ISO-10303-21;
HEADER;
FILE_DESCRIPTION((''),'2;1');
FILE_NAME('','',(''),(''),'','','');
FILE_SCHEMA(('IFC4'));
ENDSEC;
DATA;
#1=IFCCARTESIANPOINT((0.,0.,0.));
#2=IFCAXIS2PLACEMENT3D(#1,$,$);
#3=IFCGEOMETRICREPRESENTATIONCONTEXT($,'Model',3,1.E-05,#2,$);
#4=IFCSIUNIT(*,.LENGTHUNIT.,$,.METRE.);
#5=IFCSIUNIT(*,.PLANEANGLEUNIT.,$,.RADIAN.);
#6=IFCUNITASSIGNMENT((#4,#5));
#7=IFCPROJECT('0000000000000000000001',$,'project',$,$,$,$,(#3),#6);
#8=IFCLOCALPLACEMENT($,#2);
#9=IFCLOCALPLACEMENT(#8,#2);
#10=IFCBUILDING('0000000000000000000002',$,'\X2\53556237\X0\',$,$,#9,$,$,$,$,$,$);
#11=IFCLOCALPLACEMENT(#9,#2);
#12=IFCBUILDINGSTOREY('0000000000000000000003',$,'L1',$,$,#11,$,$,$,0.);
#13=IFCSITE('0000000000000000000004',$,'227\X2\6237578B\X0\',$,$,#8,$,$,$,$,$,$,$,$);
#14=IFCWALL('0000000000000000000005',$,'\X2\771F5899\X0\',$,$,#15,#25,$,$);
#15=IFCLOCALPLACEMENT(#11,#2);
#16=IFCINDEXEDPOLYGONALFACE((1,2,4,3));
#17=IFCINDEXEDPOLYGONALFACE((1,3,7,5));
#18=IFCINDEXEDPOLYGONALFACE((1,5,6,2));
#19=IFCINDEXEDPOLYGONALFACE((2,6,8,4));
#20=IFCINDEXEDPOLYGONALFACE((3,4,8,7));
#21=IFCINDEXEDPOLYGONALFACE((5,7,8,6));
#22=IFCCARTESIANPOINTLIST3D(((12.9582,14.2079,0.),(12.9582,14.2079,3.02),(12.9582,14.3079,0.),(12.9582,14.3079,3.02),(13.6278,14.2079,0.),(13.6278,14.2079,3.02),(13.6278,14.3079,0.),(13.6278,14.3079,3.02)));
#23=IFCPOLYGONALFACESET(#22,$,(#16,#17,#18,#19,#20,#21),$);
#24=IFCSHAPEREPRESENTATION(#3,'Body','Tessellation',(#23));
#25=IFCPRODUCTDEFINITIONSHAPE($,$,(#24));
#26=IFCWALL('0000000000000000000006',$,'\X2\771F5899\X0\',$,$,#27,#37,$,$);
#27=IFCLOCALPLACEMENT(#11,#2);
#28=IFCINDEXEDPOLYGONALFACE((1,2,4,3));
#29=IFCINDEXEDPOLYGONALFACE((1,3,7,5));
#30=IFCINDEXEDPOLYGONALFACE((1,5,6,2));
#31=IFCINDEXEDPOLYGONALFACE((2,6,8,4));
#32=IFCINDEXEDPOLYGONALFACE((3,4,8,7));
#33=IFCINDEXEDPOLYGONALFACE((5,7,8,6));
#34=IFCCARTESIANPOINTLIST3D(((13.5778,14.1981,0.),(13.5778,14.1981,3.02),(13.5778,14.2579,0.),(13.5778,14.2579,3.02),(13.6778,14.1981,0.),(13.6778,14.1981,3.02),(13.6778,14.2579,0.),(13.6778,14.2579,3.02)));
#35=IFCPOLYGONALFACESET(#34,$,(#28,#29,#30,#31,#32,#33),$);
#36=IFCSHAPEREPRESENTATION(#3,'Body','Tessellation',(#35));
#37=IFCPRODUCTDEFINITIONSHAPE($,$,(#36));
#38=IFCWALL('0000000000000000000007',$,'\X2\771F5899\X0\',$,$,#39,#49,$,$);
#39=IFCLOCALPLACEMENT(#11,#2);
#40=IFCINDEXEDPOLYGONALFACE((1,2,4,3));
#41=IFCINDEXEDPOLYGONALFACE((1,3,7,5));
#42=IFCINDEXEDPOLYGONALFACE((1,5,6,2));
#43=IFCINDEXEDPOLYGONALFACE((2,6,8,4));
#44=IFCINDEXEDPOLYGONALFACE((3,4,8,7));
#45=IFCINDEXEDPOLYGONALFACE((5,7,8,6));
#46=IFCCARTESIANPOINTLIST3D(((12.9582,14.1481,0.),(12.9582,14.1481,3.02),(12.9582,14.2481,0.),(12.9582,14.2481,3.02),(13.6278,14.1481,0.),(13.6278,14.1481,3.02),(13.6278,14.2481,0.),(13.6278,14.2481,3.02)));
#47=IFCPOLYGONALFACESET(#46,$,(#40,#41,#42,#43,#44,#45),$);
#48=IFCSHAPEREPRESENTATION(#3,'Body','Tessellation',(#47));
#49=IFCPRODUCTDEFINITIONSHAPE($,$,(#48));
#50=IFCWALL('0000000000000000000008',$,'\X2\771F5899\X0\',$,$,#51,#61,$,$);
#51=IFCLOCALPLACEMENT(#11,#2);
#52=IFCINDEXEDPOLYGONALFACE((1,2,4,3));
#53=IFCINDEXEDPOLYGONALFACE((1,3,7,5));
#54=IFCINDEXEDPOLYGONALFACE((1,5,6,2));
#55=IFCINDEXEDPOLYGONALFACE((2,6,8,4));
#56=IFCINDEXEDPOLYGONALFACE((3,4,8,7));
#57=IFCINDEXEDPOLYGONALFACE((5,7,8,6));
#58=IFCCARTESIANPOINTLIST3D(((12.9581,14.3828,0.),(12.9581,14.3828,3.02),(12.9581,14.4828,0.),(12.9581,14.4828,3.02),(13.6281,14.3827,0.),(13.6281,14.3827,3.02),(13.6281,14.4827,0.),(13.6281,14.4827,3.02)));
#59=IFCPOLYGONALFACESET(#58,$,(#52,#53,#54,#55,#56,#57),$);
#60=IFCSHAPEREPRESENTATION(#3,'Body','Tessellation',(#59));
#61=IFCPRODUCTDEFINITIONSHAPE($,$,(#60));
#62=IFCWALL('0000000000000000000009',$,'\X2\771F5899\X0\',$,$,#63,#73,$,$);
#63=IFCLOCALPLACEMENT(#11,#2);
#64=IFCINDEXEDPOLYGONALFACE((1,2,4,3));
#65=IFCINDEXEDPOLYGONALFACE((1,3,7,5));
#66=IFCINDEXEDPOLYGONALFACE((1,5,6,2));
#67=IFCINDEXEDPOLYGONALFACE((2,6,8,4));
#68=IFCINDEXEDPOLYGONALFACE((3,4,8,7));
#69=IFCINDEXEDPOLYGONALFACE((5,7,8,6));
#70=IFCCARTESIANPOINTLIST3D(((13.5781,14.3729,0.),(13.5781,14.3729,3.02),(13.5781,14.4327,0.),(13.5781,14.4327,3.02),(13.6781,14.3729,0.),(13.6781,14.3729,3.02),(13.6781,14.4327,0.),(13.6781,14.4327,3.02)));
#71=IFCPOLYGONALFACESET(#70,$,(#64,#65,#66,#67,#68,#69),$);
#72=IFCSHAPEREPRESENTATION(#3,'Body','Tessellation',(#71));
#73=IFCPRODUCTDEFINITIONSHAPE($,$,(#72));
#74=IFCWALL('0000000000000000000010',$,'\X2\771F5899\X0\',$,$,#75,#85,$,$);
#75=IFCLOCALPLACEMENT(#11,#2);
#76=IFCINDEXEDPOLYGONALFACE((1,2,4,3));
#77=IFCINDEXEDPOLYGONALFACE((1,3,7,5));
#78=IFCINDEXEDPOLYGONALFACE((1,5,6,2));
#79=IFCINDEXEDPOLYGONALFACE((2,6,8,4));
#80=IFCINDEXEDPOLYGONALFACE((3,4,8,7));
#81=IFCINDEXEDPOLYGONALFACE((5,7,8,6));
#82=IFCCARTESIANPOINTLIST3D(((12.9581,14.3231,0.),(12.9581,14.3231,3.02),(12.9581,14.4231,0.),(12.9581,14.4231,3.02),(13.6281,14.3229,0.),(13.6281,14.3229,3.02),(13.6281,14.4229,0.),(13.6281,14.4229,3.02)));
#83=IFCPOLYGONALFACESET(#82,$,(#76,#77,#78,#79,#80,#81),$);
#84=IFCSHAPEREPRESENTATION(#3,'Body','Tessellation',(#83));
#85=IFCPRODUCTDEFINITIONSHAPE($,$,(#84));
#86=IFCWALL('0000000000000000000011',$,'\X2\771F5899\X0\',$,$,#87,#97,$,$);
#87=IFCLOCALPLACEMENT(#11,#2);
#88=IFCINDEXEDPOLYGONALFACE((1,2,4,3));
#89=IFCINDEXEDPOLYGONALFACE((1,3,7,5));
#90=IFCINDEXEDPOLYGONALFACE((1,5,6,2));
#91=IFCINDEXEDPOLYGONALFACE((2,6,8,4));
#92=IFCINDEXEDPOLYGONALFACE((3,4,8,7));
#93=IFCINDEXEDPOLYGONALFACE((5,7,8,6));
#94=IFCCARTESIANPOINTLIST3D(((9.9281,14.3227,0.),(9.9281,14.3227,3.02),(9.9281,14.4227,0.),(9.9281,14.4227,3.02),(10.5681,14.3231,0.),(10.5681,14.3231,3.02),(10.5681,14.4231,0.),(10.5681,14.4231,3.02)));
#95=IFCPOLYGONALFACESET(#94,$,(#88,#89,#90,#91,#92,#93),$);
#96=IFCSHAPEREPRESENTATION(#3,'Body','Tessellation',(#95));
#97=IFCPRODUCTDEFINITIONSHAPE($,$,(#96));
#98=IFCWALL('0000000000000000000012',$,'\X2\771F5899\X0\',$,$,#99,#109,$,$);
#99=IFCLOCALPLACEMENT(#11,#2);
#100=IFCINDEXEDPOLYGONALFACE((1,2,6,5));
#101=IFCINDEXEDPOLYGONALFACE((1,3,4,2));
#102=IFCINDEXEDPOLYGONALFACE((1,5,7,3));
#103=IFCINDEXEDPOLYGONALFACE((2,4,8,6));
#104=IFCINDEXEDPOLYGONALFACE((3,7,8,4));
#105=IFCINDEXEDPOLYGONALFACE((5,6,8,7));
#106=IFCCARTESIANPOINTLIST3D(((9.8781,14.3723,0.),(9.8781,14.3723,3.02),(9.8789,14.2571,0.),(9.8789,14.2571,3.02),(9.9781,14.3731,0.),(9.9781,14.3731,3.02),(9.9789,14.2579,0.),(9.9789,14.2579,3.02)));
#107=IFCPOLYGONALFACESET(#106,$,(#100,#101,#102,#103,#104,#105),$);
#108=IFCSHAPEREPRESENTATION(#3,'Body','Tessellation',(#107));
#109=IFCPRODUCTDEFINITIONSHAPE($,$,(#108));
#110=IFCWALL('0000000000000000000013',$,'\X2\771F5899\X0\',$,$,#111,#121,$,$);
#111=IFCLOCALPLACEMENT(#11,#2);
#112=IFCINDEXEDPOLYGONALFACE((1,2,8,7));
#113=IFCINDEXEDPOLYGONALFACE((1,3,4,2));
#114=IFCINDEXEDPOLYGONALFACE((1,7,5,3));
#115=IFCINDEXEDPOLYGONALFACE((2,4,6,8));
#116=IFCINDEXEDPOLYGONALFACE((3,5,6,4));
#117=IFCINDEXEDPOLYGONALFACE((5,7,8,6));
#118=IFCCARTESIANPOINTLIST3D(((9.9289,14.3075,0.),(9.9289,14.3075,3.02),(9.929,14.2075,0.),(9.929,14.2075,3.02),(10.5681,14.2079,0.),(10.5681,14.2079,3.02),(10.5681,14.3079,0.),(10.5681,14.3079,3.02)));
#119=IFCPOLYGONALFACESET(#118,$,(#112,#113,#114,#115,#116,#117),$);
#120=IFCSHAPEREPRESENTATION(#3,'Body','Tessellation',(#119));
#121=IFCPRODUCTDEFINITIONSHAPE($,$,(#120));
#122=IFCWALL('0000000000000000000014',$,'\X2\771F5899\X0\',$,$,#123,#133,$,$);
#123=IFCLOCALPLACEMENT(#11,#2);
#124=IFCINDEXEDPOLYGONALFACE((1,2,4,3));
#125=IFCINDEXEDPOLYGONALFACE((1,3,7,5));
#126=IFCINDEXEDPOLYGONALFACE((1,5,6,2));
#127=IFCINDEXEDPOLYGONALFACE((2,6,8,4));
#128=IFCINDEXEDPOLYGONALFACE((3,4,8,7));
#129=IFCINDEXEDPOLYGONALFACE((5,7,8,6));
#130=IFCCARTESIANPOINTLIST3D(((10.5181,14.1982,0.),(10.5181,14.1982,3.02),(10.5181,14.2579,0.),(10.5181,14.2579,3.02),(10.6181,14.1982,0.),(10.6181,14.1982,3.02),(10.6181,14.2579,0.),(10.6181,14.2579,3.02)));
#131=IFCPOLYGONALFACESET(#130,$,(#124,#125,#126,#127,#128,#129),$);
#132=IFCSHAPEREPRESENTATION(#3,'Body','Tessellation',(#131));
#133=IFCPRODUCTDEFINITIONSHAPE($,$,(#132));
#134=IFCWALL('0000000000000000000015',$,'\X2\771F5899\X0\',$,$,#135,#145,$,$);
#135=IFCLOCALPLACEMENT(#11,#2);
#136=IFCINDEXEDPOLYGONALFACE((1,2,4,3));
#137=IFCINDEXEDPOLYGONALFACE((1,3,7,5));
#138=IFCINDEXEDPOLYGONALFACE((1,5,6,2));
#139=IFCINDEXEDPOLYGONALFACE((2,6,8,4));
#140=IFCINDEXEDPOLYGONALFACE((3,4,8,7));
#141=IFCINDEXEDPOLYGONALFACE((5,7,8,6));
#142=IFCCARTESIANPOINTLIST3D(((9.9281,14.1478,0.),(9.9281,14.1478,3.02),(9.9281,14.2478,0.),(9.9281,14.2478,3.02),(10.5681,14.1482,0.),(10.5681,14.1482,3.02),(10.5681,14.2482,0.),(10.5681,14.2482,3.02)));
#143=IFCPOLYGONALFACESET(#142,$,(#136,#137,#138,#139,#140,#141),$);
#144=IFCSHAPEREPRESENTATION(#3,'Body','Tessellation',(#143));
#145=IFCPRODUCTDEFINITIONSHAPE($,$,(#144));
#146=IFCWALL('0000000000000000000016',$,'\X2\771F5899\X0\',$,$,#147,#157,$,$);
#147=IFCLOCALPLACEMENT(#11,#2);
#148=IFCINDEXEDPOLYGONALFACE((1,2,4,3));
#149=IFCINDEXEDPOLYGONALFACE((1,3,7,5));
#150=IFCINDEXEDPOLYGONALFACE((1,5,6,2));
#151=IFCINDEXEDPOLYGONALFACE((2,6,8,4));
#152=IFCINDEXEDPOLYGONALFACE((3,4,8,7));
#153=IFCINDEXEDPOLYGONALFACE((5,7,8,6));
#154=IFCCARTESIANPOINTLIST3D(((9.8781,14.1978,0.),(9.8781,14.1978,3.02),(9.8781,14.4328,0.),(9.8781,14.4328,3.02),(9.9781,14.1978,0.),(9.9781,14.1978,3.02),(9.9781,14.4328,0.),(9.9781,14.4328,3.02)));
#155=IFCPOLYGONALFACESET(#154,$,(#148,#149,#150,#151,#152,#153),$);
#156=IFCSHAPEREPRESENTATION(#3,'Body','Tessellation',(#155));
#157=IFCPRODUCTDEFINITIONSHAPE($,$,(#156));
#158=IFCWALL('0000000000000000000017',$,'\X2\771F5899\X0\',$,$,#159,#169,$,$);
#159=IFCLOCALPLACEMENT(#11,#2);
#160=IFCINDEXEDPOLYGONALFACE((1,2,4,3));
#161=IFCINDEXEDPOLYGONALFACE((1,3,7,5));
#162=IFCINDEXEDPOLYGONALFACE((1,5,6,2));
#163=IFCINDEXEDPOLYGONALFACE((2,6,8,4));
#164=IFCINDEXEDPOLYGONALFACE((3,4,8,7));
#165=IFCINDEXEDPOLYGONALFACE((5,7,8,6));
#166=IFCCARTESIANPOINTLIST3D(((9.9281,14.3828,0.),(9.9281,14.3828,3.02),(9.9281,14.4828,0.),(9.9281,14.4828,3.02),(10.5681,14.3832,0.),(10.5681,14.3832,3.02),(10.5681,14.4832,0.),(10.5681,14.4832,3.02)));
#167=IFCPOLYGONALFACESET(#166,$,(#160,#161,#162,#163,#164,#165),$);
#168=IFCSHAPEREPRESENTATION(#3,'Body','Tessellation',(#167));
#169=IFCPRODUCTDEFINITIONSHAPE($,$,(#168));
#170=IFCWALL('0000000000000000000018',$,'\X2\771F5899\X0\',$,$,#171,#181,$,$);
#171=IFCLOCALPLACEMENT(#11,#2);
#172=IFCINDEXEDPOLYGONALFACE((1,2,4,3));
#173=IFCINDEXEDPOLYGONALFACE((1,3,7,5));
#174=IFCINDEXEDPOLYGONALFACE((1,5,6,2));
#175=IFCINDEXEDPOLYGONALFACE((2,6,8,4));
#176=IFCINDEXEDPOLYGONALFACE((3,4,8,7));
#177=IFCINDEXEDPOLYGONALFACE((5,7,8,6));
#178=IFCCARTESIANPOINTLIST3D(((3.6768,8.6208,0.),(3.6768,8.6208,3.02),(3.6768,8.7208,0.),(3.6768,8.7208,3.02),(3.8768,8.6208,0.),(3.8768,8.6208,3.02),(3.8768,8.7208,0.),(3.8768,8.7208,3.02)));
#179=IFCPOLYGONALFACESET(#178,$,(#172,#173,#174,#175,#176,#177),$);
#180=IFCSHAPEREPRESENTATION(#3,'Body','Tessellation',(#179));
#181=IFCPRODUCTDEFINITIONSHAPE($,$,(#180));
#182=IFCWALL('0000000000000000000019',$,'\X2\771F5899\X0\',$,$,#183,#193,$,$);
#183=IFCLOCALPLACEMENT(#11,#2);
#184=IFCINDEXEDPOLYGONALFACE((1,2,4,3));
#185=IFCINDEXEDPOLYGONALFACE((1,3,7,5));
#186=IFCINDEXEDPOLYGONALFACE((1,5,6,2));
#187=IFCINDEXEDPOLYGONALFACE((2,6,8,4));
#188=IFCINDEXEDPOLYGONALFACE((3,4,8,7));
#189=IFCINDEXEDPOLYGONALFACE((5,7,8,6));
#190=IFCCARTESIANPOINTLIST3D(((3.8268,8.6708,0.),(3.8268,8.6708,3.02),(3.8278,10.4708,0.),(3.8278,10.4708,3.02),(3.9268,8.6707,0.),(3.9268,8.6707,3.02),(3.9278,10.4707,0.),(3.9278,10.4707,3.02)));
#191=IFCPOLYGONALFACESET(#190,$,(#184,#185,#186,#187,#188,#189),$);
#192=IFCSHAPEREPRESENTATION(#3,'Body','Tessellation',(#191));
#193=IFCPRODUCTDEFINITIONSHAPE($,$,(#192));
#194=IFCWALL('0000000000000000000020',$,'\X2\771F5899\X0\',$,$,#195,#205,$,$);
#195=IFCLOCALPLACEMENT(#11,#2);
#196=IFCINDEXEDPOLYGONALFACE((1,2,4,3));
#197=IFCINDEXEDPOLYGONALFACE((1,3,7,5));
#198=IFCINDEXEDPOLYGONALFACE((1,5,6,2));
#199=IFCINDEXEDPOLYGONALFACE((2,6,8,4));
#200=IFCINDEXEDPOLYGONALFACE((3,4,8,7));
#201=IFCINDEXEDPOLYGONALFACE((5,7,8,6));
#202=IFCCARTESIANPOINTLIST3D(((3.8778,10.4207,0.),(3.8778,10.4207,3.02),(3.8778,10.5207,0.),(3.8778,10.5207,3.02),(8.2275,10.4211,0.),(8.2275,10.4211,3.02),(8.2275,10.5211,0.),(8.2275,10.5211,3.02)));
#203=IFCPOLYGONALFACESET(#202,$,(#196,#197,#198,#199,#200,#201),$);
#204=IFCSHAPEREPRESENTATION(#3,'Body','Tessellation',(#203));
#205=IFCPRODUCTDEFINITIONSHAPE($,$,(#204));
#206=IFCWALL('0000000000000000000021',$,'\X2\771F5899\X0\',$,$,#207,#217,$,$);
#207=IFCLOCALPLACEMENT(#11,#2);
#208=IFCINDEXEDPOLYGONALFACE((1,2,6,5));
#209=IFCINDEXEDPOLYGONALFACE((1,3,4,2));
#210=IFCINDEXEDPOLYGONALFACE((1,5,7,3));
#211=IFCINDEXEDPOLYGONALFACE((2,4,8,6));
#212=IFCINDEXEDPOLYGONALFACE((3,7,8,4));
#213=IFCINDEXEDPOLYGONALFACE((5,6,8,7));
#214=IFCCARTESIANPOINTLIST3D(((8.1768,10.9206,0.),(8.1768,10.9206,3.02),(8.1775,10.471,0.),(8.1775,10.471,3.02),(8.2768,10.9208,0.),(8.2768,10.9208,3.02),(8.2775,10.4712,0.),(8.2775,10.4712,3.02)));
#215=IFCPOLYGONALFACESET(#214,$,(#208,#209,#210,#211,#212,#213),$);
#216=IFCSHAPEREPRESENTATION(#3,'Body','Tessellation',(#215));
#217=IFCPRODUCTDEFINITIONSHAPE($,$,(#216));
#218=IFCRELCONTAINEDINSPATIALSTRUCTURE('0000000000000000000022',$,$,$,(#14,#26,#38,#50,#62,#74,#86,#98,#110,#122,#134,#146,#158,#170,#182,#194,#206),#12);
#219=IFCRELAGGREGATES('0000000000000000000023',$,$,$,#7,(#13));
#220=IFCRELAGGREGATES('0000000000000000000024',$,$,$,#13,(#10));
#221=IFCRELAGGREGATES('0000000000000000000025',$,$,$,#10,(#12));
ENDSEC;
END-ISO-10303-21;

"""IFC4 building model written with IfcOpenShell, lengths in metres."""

from ifc_helpers import new_model, si_unit, origin, place, context, project, spatial, polyline, outline, extrude, element, save


model = new_model("IFC4")

# Units and contexts
model_context = context("Model", 3, precision=1e-05, world=origin())
ifc_project = project(units=[si_unit("LENGTHUNIT", "METRE"), si_unit("PLANEANGLEUNIT", "RADIAN")], contexts=[model_context])

# Site, building, storey
site_placement = place(None, origin())
site = spatial("IfcSite", under=ifc_project, at=site_placement, Name="227户型")
building_placement = place(site_placement, origin())
building = spatial("IfcBuilding", under=site, at=building_placement, Name="单户")
storey_placement = place(building_placement, origin())
storey = spatial("IfcBuildingStorey", under=building, at=storey_placement, Name="L1", Elevation=0.0)

# Walls
wall_1_placement = place(storey_placement, origin())
element("IfcWall", 1, at=wall_1_placement, inside=storey, Name="真墙", context=model_context, shape_type="SweptSolid", body=[
    extrude(outline(polyline([(12.9582, 14.3079), (13.6278, 14.3079), (13.6278, 14.2079), (12.9582, 14.2079), (12.9582, 14.3079)])), origin(), (0.0, 0.0, 1.0), 3.02),
])
wall_2_placement = place(storey_placement, origin())
element("IfcWall", 2, at=wall_2_placement, inside=storey, Name="真墙", context=model_context, shape_type="SweptSolid", body=[
    extrude(outline(polyline([(13.6778, 14.2579), (13.6778, 14.1981), (13.5778, 14.1981), (13.5778, 14.2579), (13.6778, 14.2579)])), origin(), (0.0, 0.0, 1.0), 3.02),
])
wall_3_placement = place(storey_placement, origin())
element("IfcWall", 3, at=wall_3_placement, inside=storey, Name="真墙", context=model_context, shape_type="SweptSolid", body=[
    extrude(outline(polyline([(13.6278, 14.1481), (12.9582, 14.1481), (12.9582, 14.2481), (13.6278, 14.2481), (13.6278, 14.1481)])), origin(), (0.0, 0.0, 1.0), 3.02),
])
wall_4_placement = place(storey_placement, origin())
element("IfcWall", 4, at=wall_4_placement, inside=storey, Name="真墙", context=model_context, shape_type="SweptSolid", body=[
    extrude(outline(polyline([(12.9581, 14.4828), (13.6281, 14.4827), (13.6281, 14.3827), (12.9581, 14.3828), (12.9581, 14.4828)])), origin(), (0.0, 0.0, 1.0), 3.02),
])
wall_5_placement = place(storey_placement, origin())
element("IfcWall", 5, at=wall_5_placement, inside=storey, Name="真墙", context=model_context, shape_type="SweptSolid", body=[
    extrude(outline(polyline([(13.6781, 14.4327), (13.6781, 14.3729), (13.5781, 14.3729), (13.5781, 14.4327), (13.6781, 14.4327)])), origin(), (0.0, 0.0, 1.0), 3.02),
])
wall_6_placement = place(storey_placement, origin())
element("IfcWall", 6, at=wall_6_placement, inside=storey, Name="真墙", context=model_context, shape_type="SweptSolid", body=[
    extrude(outline(polyline([(13.6281, 14.3229), (12.9581, 14.3231), (12.9581, 14.4231), (13.6281, 14.4229), (13.6281, 14.3229)])), origin(), (0.0, 0.0, 1.0), 3.02),
])
wall_7_placement = place(storey_placement, origin())
element("IfcWall", 7, at=wall_7_placement, inside=storey, Name="真墙", context=model_context, shape_type="SweptSolid", body=[
    extrude(outline(polyline([(10.5681, 14.3231), (9.9281, 14.3227), (9.9281, 14.4227), (10.5681, 14.4231), (10.5681, 14.3231)])), origin(), (0.0, 0.0, 1.0), 3.02),
])
wall_8_placement = place(storey_placement, origin())
element("IfcWall", 8, at=wall_8_placement, inside=storey, Name="真墙", context=model_context, shape_type="SweptSolid", body=[
    extrude(outline(polyline([(9.9781, 14.3731), (9.9789, 14.2579), (9.8789, 14.2571), (9.8781, 14.3723), (9.9781, 14.3731)])), origin(), (0.0, 0.0, 1.0), 3.02),
])
wall_9_placement = place(storey_placement, origin())
element("IfcWall", 9, at=wall_9_placement, inside=storey, Name="真墙", context=model_context, shape_type="SweptSolid", body=[
    extrude(outline(polyline([(9.9289, 14.3075), (10.5681, 14.3079), (10.5681, 14.2079), (9.929, 14.2075), (9.9289, 14.3075)])), origin(), (0.0, 0.0, 1.0), 3.02),
])
wall_10_placement = place(storey_placement, origin())
element("IfcWall", 10, at=wall_10_placement, inside=storey, Name="真墙", context=model_context, shape_type="SweptSolid", body=[
    extrude(outline(polyline([(10.6181, 14.2579), (10.6181, 14.1982), (10.5181, 14.1982), (10.5181, 14.2579), (10.6181, 14.2579)])), origin(), (0.0, 0.0, 1.0), 3.02),
])
wall_11_placement = place(storey_placement, origin())
element("IfcWall", 11, at=wall_11_placement, inside=storey, Name="真墙", context=model_context, shape_type="SweptSolid", body=[
    extrude(outline(polyline([(10.5681, 14.1482), (9.9281, 14.1478), (9.9281, 14.2478), (10.5681, 14.2482), (10.5681, 14.1482)])), origin(), (0.0, 0.0, 1.0), 3.02),
])
wall_12_placement = place(storey_placement, origin())
element("IfcWall", 12, at=wall_12_placement, inside=storey, Name="真墙", context=model_context, shape_type="SweptSolid", body=[
    extrude(outline(polyline([(9.8781, 14.1978), (9.8781, 14.4328), (9.9781, 14.4328), (9.9781, 14.1978), (9.8781, 14.1978)])), origin(), (0.0, 0.0, 1.0), 3.02),
])
wall_13_placement = place(storey_placement, origin())
element("IfcWall", 13, at=wall_13_placement, inside=storey, Name="真墙", context=model_context, shape_type="SweptSolid", body=[
    extrude(outline(polyline([(9.9281, 14.4828), (10.5681, 14.4832), (10.5681, 14.3832), (9.9281, 14.3828), (9.9281, 14.4828)])), origin(), (0.0, 0.0, 1.0), 3.02),
])
wall_14_placement = place(storey_placement, origin())
element("IfcWall", 14, at=wall_14_placement, inside=storey, Name="真墙", context=model_context, shape_type="SweptSolid", body=[
    extrude(outline(polyline([(3.6768, 8.7208), (3.8768, 8.7208), (3.8768, 8.6208), (3.6768, 8.6208), (3.6768, 8.7208)])), origin(), (0.0, 0.0, 1.0), 3.02),
])
wall_15_placement = place(storey_placement, origin())
element("IfcWall", 15, at=wall_15_placement, inside=storey, Name="真墙", context=model_context, shape_type="SweptSolid", body=[
    extrude(outline(polyline([(3.8268, 8.6708), (3.8278, 10.4708), (3.9278, 10.4707), (3.9268, 8.6707), (3.8268, 8.6708)])), origin(), (0.0, 0.0, 1.0), 3.02),
])
wall_16_placement = place(storey_placement, origin())
element("IfcWall", 16, at=wall_16_placement, inside=storey, Name="真墙", context=model_context, shape_type="SweptSolid", body=[
    extrude(outline(polyline([(3.8778, 10.5207), (8.2275, 10.5211), (8.2275, 10.4211), (3.8778, 10.4207), (3.8778, 10.5207)])), origin(), (0.0, 0.0, 1.0), 3.02),
])
wall_17_placement = place(storey_placement, origin())
element("IfcWall", 17, at=wall_17_placement, inside=storey, Name="真墙", context=model_context, shape_type="SweptSolid", body=[
    extrude(outline(polyline([(8.1775, 10.471), (8.1768, 10.9206), (8.2768, 10.9208), (8.2775, 10.4712), (8.1775, 10.471)])), origin(), (0.0, 0.0, 1.0), 3.02),
])

save(model, "model.ifc")
